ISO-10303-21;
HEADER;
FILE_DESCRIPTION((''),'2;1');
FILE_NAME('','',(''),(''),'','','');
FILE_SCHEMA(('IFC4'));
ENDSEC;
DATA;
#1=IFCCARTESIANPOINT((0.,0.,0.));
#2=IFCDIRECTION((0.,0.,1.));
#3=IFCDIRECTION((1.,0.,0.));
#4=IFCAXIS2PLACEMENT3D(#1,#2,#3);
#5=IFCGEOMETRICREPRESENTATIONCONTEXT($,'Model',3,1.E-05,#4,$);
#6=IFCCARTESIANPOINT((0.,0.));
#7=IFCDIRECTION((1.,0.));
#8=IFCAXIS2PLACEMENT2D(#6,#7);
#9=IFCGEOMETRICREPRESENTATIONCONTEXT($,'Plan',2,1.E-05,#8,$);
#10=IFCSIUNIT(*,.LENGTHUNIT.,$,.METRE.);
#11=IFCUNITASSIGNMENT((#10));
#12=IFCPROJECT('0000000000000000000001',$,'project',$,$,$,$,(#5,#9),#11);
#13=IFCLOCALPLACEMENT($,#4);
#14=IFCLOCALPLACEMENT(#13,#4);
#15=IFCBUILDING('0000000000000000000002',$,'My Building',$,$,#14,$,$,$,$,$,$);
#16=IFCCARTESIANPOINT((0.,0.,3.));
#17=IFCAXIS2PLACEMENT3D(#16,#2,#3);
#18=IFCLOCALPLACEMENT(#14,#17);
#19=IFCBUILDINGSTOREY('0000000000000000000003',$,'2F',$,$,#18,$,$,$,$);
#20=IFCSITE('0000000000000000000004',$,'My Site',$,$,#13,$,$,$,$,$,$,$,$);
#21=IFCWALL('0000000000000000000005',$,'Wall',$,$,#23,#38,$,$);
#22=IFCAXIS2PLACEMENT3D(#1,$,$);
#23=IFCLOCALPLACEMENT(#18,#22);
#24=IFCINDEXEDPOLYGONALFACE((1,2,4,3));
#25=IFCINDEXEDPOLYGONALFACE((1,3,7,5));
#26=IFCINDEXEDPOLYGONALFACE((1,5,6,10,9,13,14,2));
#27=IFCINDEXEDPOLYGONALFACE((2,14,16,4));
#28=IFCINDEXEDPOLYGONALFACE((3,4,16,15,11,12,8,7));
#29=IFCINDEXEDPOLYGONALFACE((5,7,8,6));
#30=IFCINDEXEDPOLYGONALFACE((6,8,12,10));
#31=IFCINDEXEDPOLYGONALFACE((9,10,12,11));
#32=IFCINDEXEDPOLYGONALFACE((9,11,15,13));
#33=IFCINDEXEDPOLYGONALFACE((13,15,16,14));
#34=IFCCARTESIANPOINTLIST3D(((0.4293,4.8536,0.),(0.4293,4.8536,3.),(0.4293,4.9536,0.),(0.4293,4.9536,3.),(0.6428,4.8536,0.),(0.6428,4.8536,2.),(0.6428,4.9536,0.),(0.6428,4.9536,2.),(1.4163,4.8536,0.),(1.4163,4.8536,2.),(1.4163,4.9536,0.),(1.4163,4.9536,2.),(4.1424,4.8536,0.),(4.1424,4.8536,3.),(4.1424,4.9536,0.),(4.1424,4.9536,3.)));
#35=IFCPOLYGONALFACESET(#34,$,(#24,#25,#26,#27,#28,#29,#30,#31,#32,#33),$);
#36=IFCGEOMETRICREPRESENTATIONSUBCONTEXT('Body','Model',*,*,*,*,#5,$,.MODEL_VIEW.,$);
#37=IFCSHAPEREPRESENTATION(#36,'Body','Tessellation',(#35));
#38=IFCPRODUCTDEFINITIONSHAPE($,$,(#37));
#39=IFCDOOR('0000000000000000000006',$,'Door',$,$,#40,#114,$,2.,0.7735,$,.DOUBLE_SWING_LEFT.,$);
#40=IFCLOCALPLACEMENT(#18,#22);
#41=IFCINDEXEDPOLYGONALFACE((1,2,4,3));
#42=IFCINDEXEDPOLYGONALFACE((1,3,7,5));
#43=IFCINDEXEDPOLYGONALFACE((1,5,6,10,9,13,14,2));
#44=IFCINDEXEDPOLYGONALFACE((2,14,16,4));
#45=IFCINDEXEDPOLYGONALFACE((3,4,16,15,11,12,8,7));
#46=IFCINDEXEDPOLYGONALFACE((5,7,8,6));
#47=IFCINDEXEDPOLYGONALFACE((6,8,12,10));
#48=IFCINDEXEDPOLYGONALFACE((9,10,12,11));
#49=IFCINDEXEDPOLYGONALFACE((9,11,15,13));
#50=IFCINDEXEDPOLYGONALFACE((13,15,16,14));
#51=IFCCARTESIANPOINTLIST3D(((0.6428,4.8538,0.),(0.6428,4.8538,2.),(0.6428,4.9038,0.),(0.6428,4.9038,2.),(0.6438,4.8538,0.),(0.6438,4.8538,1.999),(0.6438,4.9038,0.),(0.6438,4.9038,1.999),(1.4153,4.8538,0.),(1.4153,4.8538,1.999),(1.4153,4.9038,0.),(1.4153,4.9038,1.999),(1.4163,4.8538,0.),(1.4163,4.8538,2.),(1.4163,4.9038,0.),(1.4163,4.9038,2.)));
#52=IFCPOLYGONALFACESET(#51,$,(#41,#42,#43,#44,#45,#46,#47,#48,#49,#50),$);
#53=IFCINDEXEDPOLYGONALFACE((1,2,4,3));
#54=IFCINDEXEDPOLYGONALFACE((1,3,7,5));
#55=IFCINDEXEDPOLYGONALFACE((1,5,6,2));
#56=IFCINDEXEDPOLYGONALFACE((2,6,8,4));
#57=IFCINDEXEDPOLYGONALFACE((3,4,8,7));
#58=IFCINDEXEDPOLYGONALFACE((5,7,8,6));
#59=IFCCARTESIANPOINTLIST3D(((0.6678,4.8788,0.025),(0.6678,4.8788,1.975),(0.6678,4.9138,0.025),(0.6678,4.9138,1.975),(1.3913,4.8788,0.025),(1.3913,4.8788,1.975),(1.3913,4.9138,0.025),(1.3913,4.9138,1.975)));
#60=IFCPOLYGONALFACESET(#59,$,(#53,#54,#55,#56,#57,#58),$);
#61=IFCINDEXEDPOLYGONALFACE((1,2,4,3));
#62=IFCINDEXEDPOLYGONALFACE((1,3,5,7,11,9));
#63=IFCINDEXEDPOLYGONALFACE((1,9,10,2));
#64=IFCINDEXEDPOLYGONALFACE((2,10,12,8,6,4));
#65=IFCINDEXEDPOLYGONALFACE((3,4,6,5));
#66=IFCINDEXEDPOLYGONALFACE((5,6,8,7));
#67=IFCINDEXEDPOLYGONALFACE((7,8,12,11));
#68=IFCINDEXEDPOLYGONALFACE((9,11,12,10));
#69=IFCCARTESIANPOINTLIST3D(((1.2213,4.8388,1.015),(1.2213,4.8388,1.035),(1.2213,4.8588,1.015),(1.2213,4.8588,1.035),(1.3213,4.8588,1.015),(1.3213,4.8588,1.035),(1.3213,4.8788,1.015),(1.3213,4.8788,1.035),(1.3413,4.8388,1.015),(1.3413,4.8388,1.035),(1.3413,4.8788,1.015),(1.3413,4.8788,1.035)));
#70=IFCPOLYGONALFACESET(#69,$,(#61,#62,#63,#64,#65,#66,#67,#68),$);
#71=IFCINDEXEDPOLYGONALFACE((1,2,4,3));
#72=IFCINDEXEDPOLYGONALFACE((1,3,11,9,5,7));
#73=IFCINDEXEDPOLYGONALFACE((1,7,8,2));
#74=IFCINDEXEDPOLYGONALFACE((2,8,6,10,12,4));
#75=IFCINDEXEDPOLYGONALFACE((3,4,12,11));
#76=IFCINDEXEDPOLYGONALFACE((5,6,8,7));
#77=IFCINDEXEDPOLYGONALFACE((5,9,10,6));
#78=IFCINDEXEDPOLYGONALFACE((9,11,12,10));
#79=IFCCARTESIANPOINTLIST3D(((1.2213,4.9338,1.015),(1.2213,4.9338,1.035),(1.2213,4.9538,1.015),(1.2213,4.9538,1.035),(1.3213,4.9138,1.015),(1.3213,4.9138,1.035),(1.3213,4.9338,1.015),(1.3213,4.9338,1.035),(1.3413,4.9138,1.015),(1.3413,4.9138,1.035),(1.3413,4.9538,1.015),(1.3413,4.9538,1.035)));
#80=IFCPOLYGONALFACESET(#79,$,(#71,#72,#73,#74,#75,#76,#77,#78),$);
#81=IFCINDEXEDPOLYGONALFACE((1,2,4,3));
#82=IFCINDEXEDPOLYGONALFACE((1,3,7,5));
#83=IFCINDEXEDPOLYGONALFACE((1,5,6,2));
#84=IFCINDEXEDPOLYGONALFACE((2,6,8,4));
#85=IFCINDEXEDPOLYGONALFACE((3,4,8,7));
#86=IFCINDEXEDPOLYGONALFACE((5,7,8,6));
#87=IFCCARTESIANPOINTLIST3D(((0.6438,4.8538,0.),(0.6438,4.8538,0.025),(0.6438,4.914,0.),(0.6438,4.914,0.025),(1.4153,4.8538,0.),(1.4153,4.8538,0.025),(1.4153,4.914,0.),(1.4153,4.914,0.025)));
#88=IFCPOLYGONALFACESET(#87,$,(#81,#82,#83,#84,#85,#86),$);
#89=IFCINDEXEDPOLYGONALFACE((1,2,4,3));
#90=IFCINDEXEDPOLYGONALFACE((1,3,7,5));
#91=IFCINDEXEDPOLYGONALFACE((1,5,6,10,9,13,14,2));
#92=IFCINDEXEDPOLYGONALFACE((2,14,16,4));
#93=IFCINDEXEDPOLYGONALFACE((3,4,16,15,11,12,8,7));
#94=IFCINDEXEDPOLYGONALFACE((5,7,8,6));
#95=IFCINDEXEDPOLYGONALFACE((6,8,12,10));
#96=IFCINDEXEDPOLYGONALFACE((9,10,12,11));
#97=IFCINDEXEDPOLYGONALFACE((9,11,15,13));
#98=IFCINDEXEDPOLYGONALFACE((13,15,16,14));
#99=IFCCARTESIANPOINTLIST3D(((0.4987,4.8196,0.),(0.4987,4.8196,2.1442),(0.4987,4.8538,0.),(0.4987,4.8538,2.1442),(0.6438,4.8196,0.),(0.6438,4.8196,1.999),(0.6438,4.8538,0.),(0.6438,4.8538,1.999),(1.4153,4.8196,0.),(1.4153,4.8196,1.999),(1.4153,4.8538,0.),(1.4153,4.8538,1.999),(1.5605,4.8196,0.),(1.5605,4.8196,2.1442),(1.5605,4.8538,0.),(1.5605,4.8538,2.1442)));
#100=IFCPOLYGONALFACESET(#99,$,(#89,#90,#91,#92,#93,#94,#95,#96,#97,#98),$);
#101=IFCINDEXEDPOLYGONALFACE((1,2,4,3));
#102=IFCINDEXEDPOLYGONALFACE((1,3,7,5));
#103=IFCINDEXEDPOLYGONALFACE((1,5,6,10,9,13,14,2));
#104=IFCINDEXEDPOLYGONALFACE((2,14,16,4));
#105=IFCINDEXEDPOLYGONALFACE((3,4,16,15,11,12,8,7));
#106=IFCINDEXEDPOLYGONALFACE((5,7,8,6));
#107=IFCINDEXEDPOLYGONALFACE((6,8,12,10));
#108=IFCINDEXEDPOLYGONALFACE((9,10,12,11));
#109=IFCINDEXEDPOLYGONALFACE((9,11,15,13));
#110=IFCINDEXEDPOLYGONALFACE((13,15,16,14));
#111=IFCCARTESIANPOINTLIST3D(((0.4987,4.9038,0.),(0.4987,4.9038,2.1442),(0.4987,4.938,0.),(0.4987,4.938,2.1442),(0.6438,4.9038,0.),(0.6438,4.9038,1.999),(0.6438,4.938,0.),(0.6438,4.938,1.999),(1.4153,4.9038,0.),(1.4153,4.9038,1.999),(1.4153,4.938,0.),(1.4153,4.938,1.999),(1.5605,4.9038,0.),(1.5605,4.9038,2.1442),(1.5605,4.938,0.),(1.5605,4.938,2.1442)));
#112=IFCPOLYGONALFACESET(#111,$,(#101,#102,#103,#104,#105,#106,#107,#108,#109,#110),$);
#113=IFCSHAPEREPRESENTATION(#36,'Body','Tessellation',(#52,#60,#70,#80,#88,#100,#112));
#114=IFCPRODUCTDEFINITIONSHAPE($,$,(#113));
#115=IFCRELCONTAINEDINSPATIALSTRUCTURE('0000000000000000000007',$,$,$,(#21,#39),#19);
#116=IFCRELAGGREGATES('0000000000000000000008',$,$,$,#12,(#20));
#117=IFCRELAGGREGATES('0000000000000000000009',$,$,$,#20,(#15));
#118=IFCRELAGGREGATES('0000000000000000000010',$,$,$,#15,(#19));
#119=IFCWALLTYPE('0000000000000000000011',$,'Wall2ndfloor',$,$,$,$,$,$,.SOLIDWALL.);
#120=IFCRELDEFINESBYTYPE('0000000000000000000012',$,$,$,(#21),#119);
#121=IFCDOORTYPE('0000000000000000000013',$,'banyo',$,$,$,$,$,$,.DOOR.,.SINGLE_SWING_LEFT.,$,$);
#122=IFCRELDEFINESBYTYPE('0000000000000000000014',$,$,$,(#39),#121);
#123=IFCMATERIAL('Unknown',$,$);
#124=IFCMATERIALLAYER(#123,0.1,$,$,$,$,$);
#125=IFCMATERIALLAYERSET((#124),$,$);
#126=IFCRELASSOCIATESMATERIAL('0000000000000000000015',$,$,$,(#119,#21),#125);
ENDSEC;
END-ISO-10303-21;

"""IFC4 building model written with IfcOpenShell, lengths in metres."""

from ifc_helpers import new_model, entity, si_unit, frame, origin_with_axes, origin_2d_with_axis, place, context, subcontext, project, spatial, line, indexed_curve, outline, extrude, shape, source, transform, mapped, material, layer, layer_set, layer_usage, type_object, type_shapes, element, fill, save


model = new_model("IFC4")

# Units and contexts
model_context = context("Model", 3, precision=1e-05, world=origin_with_axes())
plan_context = context("Plan", 2, precision=1e-05, world=origin_2d_with_axis())
body_context_1 = subcontext(model_context, "Body", "Model", "MODEL_VIEW")
body_context_2 = subcontext(plan_context, "Body", "Plan", "PLAN_VIEW")
ifc_project = project(units=[si_unit("LENGTHUNIT", "METRE")], contexts=[model_context, plan_context])

# Site, building, storey
site_placement = place(None, origin_with_axes())
site = spatial("IfcSite", under=ifc_project, at=site_placement, Name="My Site")
building_placement = place(site_placement, origin_with_axes())
building = spatial("IfcBuilding", under=site, at=building_placement, Name="My Building")
storey_placement = place(building_placement, frame((0.0, 0.0, 3.0), z_axis=(0.0, 0.0, 1.0), x_axis=(1.0, 0.0, 0.0)))
storey = spatial("IfcBuildingStorey", under=building, at=storey_placement, Name="2F")

# Shared definitions
ifc_material = material(Name="Unknown")

# Shared definitions
ifc_layer_1 = layer(ifc_material, 0.1)
ifc_layer_set_1 = layer_set([ifc_layer_1])
wall_type = type_object("IfcWallType", Name="Wall2ndfloor", PredefinedType="SOLIDWALL", material=ifc_layer_set_1)

# Wall, opening, door
ifc_layer_usage_1 = layer_usage(ifc_layer_set_1, "AXIS2", "POSITIVE", 0.0)
wall_1_placement = place(storey_placement, frame((4.2424, 4.9536, 0.0), z_axis=(0.0, 0.0, 1.0), x_axis=(-1.0, 0.0, 0.0)))
wall_1 = element("IfcWall", 1, at=wall_1_placement, inside=storey, type_object=wall_type, material=ifc_layer_usage_1, Name="Wall", context=body_context_1, shape_type="SweptSolid", body=[
    extrude(outline(indexed_curve([(0.1, 0.0), (0.1, 0.1), (3.8131, 0.1), (3.8131, 0.0)], segments=[line(1, 2, 3, 4, 1)])), origin_with_axes(), (0.0, 0.0, 1.0), 3.0),
])
shared_shape_1 = source(origin_with_axes(), body_context_1, "Body", "SweptSolid", [
    extrude(outline(indexed_curve([(0.0, 0.0), (0.7735, 0.0), (0.7735, 2.0), (0.0, 2.0)], segments=[line(1, 2, 3, 4, 1)])), frame((0.0, -0.6, 0.0), z_axis=(0.0, -1.0, 0.0), x_axis=(1.0, 0.0, 0.0)), (0.0, 0.0, -1.0), 1.2),
])
opening_1_placement = place(wall_1_placement, frame((3.5996, 0.0998, 0.0), z_axis=(0.0, 0.0, 1.0), x_axis=(-1.0, 0.0, 0.0)))
opening_1 = element("IfcOpeningElement", 2, at=opening_1_placement, cuts=wall_1, PredefinedType="OPENING", context=body_context_1, shape_type="MappedRepresentation", body=[
    mapped(shared_shape_1, transform((0.0, 0.0, 0.0), x_axis=(1.0, 0.0, 0.0), y_axis=(0.0, 1.0, 0.0), z_axis=(0.0, 0.0, 1.0), scale=1.0)),
])
door_type_1 = type_object("IfcDoorType", Name="banyo", OperationType="SINGLE_SWING_LEFT", PredefinedType="DOOR")
shared_shape_2 = source(origin_with_axes(), body_context_1, "Body", "SweptSolid", [
    extrude(outline(indexed_curve([(0.0, 0.0), (0.0, 2.0), (0.7735, 2.0), (0.7735, 0.0), (0.7725, 0.0), (0.7725, 1.999), (0.001, 1.999), (0.001, 0.0)], segments=[line(1, 2, 3, 4, 5, 6, 7, 8, 1)])), frame((0.0, 0.0, 0.0), z_axis=(0.0, -1.0, 0.0), x_axis=(1.0, 0.0, 0.0)), (0.0, 0.0, -1.0), 0.05),
    extrude(outline(indexed_curve([(0.0, 0.0), (0.7235, 0.0), (0.7235, 0.035), (0.0, 0.035)], segments=[line(1, 2, 3, 4, 1)])), frame((0.025, 0.025, 0.025), z_axis=(0.0, 0.0, 1.0), x_axis=(1.0, 0.0, 0.0)), (0.0, 0.0, 1.0), 1.95),
    extrude(outline(indexed_curve([(0.0, 0.0), (0.0, -0.04), (-0.12, -0.04), (-0.12, -0.02), (-0.02, -0.02), (-0.02, 0.0)], segments=[line(1, 2, 3, 4, 5, 6, 1)])), frame((0.6985, 0.025, 1.015), z_axis=(0.0, 0.0, 1.0), x_axis=(1.0, 0.0, 0.0)), (0.0, 0.0, 1.0), 0.02),
    extrude(outline(indexed_curve([(0.0, 0.0), (0.0, 0.04), (-0.12, 0.04), (-0.12, 0.02), (-0.02, 0.02), (-0.02, 0.0)], segments=[line(1, 2, 3, 4, 5, 6, 1)])), frame((0.6985, 0.06, 1.015), z_axis=(0.0, 0.0, 1.0), x_axis=(1.0, 0.0, 0.0)), (0.0, 0.0, 1.0), 0.02),
    extrude(outline(indexed_curve([(0.0, 0.0), (0.7715, 0.0), (0.7715, 0.0602), (0.0, 0.0602)], segments=[line(1, 2, 3, 4, 1)])), frame((0.001, 0.0, 0.0), z_axis=(0.0, 0.0, 1.0), x_axis=(1.0, 0.0, 0.0)), (0.0, 0.0, 1.0), 0.025),
    extrude(outline(indexed_curve([(0.0, 0.0), (0.0, 2.1442), (1.0618, 2.1442), (1.0618, 0.0), (0.9167, 0.0), (0.9167, 1.999), (0.1452, 1.999), (0.1452, 0.0)], segments=[line(1, 2, 3, 4, 5, 6, 7, 8, 1)])), frame((-0.1442, -0.0342, 0.0), z_axis=(0.0, -1.0, 0.0), x_axis=(1.0, 0.0, 0.0)), (0.0, 0.0, -1.0), 0.0342),
    extrude(outline(indexed_curve([(0.0, 0.0), (0.0, 2.1442), (1.0618, 2.1442), (1.0618, 0.0), (0.9167, 0.0), (0.9167, 1.999), (0.1452, 1.999), (0.1452, 0.0)], segments=[line(1, 2, 3, 4, 5, 6, 7, 8, 1)])), frame((-0.1442, 0.05, 0.0), z_axis=(0.0, -1.0, 0.0), x_axis=(1.0, 0.0, 0.0)), (0.0, 0.0, -1.0), 0.0342),
])
shared_shape_3 = source(origin_with_axes(), body_context_2, "Body", "Curve2D", [
    entity("IfcIndexedPolyCurve", entity("IfcCartesianPointList2D", [[0.0, 0.0], [0.001, 0.0], [0.001, 0.05], [0.0, 0.05]]), [entity("IfcLineIndex", [1, 2, 3, 4, 1])]),
    entity("IfcIndexedPolyCurve", entity("IfcCartesianPointList2D", [[0.7735, 0.0], [0.7725, 0.0], [0.7725, 0.05], [0.7735, 0.05]]), [entity("IfcLineIndex", [1, 2, 3, 4, 1])]),
    entity("IfcTrimmedCurve", entity("IfcEllipse", entity("IfcAxis2Placement2D", entity("IfcCartesianPoint", [0.06, 0.05]), entity("IfcDirection", [1.0, 0.0])), 0.6885, 0.7235), [entity("IfcCartesianPoint", [0.7485, 0.05])], [entity("IfcCartesianPoint", [0.06, 0.7735])], True, "CARTESIAN"),
    entity("IfcIndexedPolyCurve", entity("IfcCartesianPointList2D", [[0.025, 0.05], [0.06, 0.05], [0.06, 0.7735], [0.025, 0.7735]]), [entity("IfcLineIndex", [1, 2, 3, 4, 1])]),
])
type_shapes(door_type_1, [shared_shape_2, shared_shape_3])
door_1_placement = place(opening_1_placement, frame((0.0, 0.0, 0.0), z_axis=(0.0, 0.0, 1.0), x_axis=(1.0, 0.0, 0.0)))
door_1 = element("IfcDoor", 3, at=door_1_placement, inside=storey, type_object=door_type_1, Name="Door", OperationType="DOUBLE_SWING_LEFT", OverallHeight=2.0, OverallWidth=0.7735, shapes=[
    shape(body_context_1, "Body", "MappedRepresentation", [mapped(shared_shape_2, transform((0.0, 0.0, 0.0), x_axis=(1.0, 0.0, 0.0), y_axis=(0.0, 1.0, 0.0), z_axis=(0.0, 0.0, 1.0), scale=1.0))]),
    shape(body_context_2, "Body", "MappedRepresentation", [mapped(shared_shape_3, transform((0.0, 0.0, 0.0), x_axis=(1.0, 0.0, 0.0), y_axis=(0.0, 1.0, 0.0), z_axis=(0.0, 0.0, 1.0), scale=1.0))]),
])
fill(opening_1, door_1)

save(model, "model.ifc")
